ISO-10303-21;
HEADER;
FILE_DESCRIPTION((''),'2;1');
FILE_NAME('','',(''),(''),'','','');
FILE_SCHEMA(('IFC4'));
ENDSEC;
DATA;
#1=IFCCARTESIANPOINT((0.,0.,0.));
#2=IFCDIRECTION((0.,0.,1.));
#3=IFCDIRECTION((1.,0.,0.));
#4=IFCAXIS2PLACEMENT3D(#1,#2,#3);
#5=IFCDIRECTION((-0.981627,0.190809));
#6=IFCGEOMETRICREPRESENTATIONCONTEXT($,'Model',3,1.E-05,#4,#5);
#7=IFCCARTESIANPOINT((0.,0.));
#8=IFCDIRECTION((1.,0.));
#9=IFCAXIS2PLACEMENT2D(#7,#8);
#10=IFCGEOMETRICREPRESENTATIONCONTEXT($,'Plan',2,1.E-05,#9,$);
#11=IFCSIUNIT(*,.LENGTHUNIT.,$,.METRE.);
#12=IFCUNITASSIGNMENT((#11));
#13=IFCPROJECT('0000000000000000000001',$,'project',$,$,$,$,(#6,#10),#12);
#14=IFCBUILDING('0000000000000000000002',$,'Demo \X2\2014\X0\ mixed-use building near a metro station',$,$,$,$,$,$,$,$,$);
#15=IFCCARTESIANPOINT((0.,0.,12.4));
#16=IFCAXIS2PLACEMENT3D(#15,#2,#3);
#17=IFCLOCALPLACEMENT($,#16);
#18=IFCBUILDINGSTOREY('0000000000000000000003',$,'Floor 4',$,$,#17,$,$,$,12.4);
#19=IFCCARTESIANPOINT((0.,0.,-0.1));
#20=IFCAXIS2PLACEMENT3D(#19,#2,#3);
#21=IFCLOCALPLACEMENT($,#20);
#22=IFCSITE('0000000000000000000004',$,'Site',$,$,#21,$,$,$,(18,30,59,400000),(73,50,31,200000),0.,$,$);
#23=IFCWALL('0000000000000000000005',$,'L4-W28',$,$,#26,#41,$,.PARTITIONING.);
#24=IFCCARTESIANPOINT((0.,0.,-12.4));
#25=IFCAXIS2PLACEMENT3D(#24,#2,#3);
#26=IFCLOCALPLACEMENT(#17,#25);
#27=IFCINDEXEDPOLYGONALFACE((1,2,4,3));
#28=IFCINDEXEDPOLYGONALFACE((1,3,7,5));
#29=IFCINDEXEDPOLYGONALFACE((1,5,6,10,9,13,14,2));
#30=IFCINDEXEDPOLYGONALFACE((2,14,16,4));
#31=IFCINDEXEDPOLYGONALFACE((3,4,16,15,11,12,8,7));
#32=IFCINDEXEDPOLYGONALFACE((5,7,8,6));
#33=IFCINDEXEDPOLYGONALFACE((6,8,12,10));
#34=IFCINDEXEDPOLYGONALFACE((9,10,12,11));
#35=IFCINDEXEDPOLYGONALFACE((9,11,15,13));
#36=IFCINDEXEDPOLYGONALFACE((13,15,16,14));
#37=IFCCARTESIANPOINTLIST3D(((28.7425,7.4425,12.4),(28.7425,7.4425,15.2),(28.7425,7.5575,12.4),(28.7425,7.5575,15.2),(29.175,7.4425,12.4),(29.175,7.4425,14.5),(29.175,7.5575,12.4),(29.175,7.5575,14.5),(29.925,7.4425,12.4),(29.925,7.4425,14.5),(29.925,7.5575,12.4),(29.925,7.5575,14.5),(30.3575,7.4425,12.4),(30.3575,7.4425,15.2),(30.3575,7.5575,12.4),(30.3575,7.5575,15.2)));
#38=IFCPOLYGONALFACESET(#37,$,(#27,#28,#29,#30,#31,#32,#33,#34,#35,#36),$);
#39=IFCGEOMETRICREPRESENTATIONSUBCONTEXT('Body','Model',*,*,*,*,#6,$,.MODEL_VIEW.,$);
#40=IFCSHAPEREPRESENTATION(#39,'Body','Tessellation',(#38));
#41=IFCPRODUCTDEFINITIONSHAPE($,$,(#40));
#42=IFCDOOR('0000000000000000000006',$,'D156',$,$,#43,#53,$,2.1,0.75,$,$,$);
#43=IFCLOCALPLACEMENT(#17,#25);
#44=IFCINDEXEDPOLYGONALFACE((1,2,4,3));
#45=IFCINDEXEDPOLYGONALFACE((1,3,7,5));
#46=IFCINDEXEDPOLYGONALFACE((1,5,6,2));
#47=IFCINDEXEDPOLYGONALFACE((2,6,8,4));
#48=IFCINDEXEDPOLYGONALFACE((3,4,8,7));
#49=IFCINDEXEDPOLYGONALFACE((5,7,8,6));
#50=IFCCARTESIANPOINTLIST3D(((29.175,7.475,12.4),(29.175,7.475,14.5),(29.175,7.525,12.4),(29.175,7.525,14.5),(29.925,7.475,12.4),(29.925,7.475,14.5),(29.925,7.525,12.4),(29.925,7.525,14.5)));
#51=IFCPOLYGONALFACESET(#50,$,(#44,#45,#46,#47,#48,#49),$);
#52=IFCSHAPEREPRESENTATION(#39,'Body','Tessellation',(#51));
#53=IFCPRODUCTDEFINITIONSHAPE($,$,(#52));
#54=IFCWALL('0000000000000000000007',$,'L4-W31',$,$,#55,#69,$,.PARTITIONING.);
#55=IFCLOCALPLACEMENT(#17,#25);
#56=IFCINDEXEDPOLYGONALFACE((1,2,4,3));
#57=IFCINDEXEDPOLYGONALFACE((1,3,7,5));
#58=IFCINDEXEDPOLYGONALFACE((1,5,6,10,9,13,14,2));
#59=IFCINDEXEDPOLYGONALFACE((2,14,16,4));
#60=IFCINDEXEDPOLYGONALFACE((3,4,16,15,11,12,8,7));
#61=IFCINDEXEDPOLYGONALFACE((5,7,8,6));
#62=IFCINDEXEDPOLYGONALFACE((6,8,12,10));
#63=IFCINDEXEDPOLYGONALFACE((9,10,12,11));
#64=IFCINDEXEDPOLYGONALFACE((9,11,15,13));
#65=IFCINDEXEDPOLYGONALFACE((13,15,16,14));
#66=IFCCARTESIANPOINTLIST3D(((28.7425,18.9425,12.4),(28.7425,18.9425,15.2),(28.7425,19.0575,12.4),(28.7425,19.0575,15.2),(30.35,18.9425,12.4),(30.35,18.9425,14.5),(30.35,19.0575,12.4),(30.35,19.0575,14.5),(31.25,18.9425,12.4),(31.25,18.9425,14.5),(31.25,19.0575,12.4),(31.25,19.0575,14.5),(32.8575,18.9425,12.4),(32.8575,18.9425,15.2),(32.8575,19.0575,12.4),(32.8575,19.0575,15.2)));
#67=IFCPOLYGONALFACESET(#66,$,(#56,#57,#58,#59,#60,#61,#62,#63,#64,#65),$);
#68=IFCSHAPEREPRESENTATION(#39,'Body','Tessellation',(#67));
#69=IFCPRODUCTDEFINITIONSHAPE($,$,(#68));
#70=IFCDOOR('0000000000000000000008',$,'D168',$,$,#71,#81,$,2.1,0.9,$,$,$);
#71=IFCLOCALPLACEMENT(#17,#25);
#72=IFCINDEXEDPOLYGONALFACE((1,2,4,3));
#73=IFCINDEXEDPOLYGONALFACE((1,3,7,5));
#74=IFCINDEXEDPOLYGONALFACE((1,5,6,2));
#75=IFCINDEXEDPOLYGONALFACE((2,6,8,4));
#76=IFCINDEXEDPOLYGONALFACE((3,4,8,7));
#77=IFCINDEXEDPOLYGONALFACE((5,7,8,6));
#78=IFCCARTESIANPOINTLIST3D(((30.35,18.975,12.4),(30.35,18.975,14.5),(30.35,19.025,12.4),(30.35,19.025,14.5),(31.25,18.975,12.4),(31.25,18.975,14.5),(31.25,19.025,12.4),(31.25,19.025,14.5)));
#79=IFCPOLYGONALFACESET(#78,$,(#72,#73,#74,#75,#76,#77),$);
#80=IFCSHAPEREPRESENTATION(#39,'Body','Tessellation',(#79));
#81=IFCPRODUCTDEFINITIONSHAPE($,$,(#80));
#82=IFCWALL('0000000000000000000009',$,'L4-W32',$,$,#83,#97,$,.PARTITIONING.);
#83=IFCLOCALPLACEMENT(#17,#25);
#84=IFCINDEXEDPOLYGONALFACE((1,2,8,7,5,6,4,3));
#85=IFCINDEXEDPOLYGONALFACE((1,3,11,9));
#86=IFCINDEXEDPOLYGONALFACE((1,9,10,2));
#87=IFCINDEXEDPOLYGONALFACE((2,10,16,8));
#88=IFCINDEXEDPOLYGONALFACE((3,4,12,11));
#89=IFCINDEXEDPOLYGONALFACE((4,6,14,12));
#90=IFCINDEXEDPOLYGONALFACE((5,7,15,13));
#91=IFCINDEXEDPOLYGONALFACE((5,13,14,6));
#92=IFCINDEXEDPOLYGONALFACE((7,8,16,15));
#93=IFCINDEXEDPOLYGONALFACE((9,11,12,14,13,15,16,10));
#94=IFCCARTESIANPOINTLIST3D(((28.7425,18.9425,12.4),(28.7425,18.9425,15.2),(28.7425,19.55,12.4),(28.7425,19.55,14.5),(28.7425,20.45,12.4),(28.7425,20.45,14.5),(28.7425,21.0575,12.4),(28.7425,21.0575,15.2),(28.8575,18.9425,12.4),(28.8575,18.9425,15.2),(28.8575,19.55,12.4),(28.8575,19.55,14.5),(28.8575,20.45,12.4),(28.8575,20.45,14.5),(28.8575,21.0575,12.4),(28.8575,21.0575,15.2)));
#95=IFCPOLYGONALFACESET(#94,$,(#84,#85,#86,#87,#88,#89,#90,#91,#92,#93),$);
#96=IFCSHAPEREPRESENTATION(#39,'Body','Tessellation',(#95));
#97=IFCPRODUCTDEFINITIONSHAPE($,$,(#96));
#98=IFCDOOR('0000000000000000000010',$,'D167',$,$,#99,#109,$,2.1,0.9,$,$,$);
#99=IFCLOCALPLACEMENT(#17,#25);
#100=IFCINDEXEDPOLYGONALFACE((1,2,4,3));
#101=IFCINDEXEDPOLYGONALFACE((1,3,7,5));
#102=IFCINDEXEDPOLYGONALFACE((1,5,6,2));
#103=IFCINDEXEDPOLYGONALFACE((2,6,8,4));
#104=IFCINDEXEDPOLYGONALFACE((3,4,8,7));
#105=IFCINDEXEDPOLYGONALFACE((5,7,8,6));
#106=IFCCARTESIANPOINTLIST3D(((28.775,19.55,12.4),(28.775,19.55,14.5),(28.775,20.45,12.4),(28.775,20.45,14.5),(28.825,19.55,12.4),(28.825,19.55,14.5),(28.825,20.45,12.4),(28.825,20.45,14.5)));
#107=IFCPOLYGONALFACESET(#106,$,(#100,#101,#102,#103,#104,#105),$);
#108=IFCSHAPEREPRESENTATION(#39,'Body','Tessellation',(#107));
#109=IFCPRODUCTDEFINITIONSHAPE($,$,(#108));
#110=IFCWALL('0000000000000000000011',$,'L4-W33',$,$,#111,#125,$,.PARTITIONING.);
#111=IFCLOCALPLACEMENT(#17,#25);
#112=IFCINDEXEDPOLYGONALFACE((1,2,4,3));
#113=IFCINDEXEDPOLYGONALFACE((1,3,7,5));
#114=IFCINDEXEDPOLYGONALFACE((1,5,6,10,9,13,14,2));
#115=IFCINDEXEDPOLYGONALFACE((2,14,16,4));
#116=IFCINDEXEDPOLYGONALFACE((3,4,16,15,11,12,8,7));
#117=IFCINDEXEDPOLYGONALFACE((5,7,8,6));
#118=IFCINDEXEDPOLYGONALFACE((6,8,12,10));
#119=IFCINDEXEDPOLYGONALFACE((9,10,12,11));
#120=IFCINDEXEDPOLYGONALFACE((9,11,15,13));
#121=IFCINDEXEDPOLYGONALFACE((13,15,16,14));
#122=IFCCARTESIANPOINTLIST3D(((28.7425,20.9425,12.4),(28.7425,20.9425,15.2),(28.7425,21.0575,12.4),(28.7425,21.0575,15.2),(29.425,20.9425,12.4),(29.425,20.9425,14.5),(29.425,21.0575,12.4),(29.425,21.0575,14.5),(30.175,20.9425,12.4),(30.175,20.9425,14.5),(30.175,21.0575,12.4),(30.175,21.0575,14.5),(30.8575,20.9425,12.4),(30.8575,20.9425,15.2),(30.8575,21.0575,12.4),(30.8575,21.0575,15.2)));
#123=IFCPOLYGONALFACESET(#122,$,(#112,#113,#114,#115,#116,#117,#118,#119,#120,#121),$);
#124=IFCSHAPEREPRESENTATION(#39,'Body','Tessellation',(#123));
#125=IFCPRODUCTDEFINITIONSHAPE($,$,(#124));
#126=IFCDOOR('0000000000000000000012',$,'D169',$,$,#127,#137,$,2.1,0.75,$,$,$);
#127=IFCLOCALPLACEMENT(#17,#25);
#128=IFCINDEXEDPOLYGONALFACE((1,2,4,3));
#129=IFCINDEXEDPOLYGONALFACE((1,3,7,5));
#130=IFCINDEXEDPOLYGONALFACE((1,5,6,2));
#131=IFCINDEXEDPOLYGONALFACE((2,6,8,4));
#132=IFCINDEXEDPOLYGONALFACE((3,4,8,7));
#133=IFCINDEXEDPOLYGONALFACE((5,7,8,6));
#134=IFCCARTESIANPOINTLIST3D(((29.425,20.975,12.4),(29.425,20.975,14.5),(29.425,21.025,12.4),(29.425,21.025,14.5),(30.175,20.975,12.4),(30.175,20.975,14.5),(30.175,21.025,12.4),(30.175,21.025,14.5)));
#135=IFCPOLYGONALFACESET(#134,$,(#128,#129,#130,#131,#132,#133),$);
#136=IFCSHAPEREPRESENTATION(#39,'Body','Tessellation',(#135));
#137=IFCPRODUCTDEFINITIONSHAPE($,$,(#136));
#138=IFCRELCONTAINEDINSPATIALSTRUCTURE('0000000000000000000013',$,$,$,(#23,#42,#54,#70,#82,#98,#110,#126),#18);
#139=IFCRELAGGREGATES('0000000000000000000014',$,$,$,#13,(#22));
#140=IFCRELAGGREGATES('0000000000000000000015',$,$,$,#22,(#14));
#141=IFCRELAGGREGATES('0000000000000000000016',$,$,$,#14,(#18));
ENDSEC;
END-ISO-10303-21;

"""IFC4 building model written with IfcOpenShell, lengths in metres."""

from ifc_helpers import new_model, si_unit, direction, frame, origin_with_axes, origin_2d_with_axis, place, context, subcontext, project, spatial, line, indexed_curve, outline, extrude, element, fill, save


model = new_model("IFC4")

# Units and contexts
model_context = context("Model", 3, precision=1e-05, world=origin_with_axes(), true_north=direction((-0.981627, 0.190809)))
plan_context = context("Plan", 2, precision=1e-05, world=origin_2d_with_axis())
body_context = subcontext(model_context, "Body", "Model", "MODEL_VIEW")
ifc_project = project(units=[si_unit("LENGTHUNIT", "METRE")], contexts=[model_context, plan_context])

# Site, building, storey
site_placement = place(None, frame((0.0, 0.0, -0.1), z_axis=(0.0, 0.0, 1.0), x_axis=(1.0, 0.0, 0.0)))
site = spatial("IfcSite", under=ifc_project, at=site_placement, Name="Site", RefLatitude=(18, 30, 59, 400000), RefLongitude=(73, 50, 31, 200000), RefElevation=0.0)
building = spatial("IfcBuilding", under=site, Name="Demo — mixed-use building near a metro station")
storey_placement = place(None, frame((0.0, 0.0, 12.4), z_axis=(0.0, 0.0, 1.0), x_axis=(1.0, 0.0, 0.0)))
storey = spatial("IfcBuildingStorey", under=building, at=storey_placement, Name="Floor 4", Elevation=12.4)

# Wall, opening, door
wall_1_placement = place(storey_placement, frame((0.0, 0.0, -12.4), z_axis=(0.0, 0.0, 1.0), x_axis=(1.0, 0.0, 0.0)))
wall_1 = element("IfcWall", 1, at=wall_1_placement, inside=storey, Name="L4-W28", PredefinedType="PARTITIONING", context=body_context, shape_type="SweptSolid", body=[
    extrude(outline(indexed_curve([(30.3575, 7.4425), (28.7425, 7.4425), (28.7425, 7.5575), (30.3575, 7.5575)], segments=[line(1, 2, 3, 4, 1)])), frame((0.0, 0.0, 12.4), z_axis=(0.0, 0.0, 1.0), x_axis=(1.0, 0.0, 0.0)), (0.0, 0.0, 1.0), 2.8),
])
opening_1_placement = place(wall_1_placement, origin_with_axes())
opening_1 = element("IfcOpeningElement", 2, at=opening_1_placement, cuts=wall_1, context=body_context, shape_type="SweptSolid", body=[
    extrude(outline(indexed_curve([(29.925, 7.3925), (29.175, 7.3925), (29.175, 7.6075), (29.925, 7.6075)], segments=[line(1, 2, 3, 4, 1)])), frame((0.0, 0.0, 12.4), z_axis=(0.0, 0.0, 1.0), x_axis=(1.0, 0.0, 0.0)), (0.0, 0.0, 1.0), 2.1),
])
door_1_placement = place(storey_placement, frame((0.0, 0.0, -12.4), z_axis=(0.0, 0.0, 1.0), x_axis=(1.0, 0.0, 0.0)))
door_1 = element("IfcDoor", 3, at=door_1_placement, inside=storey, Name="D156", OverallHeight=2.1, OverallWidth=0.75, context=body_context, shape_type="SweptSolid", body=[
    extrude(outline(indexed_curve([(29.925, 7.475), (29.175, 7.475), (29.175, 7.525), (29.925, 7.525)], segments=[line(1, 2, 3, 4, 1)])), frame((0.0, 0.0, 12.4), z_axis=(0.0, 0.0, 1.0), x_axis=(1.0, 0.0, 0.0)), (0.0, 0.0, 1.0), 2.1),
])
fill(opening_1, door_1)

# Walls, openings, doors
wall_2_placement = place(storey_placement, frame((0.0, 0.0, -12.4), z_axis=(0.0, 0.0, 1.0), x_axis=(1.0, 0.0, 0.0)))
wall_2 = element("IfcWall", 4, at=wall_2_placement, inside=storey, Name="L4-W31", PredefinedType="PARTITIONING", context=body_context, shape_type="SweptSolid", body=[
    extrude(outline(indexed_curve([(32.8575, 18.9425), (28.7425, 18.9425), (28.7425, 19.0575), (32.8575, 19.0575)], segments=[line(1, 2, 3, 4, 1)])), frame((0.0, 0.0, 12.4), z_axis=(0.0, 0.0, 1.0), x_axis=(1.0, 0.0, 0.0)), (0.0, 0.0, 1.0), 2.8),
])
opening_2_placement = place(wall_2_placement, origin_with_axes())
opening_2 = element("IfcOpeningElement", 5, at=opening_2_placement, cuts=wall_2, context=body_context, shape_type="SweptSolid", body=[
    extrude(outline(indexed_curve([(31.25, 18.8925), (30.35, 18.8925), (30.35, 19.1075), (31.25, 19.1075)], segments=[line(1, 2, 3, 4, 1)])), frame((0.0, 0.0, 12.4), z_axis=(0.0, 0.0, 1.0), x_axis=(1.0, 0.0, 0.0)), (0.0, 0.0, 1.0), 2.1),
])
door_2_placement = place(storey_placement, frame((0.0, 0.0, -12.4), z_axis=(0.0, 0.0, 1.0), x_axis=(1.0, 0.0, 0.0)))
door_2 = element("IfcDoor", 6, at=door_2_placement, inside=storey, Name="D168", OverallHeight=2.1, OverallWidth=0.9, context=body_context, shape_type="SweptSolid", body=[
    extrude(outline(indexed_curve([(31.25, 18.975), (30.35, 18.975), (30.35, 19.025), (31.25, 19.025)], segments=[line(1, 2, 3, 4, 1)])), frame((0.0, 0.0, 12.4), z_axis=(0.0, 0.0, 1.0), x_axis=(1.0, 0.0, 0.0)), (0.0, 0.0, 1.0), 2.1),
])
fill(opening_2, door_2)
wall_3_placement = place(storey_placement, frame((0.0, 0.0, -12.4), z_axis=(0.0, 0.0, 1.0), x_axis=(1.0, 0.0, 0.0)))
wall_3 = element("IfcWall", 7, at=wall_3_placement, inside=storey, Name="L4-W32", PredefinedType="PARTITIONING", context=body_context, shape_type="SweptSolid", body=[
    extrude(outline(indexed_curve([(28.7425, 18.9425), (28.7425, 21.0575), (28.8575, 21.0575), (28.8575, 18.9425)], segments=[line(1, 2, 3, 4, 1)])), frame((0.0, 0.0, 12.4), z_axis=(0.0, 0.0, 1.0), x_axis=(1.0, 0.0, 0.0)), (0.0, 0.0, 1.0), 2.8),
])
opening_3_placement = place(wall_3_placement, origin_with_axes())
opening_3 = element("IfcOpeningElement", 8, at=opening_3_placement, cuts=wall_3, context=body_context, shape_type="SweptSolid", body=[
    extrude(outline(indexed_curve([(28.6925, 19.55), (28.6925, 20.45), (28.9075, 20.45), (28.9075, 19.55)], segments=[line(1, 2, 3, 4, 1)])), frame((0.0, 0.0, 12.4), z_axis=(0.0, 0.0, 1.0), x_axis=(1.0, 0.0, 0.0)), (0.0, 0.0, 1.0), 2.1),
])
door_3_placement = place(storey_placement, frame((0.0, 0.0, -12.4), z_axis=(0.0, 0.0, 1.0), x_axis=(1.0, 0.0, 0.0)))
door_3 = element("IfcDoor", 9, at=door_3_placement, inside=storey, Name="D167", OverallHeight=2.1, OverallWidth=0.9, context=body_context, shape_type="SweptSolid", body=[
    extrude(outline(indexed_curve([(28.775, 19.55), (28.775, 20.45), (28.825, 20.45), (28.825, 19.55)], segments=[line(1, 2, 3, 4, 1)])), frame((0.0, 0.0, 12.4), z_axis=(0.0, 0.0, 1.0), x_axis=(1.0, 0.0, 0.0)), (0.0, 0.0, 1.0), 2.1),
])
fill(opening_3, door_3)
wall_4_placement = place(storey_placement, frame((0.0, 0.0, -12.4), z_axis=(0.0, 0.0, 1.0), x_axis=(1.0, 0.0, 0.0)))
wall_4 = element("IfcWall", 10, at=wall_4_placement, inside=storey, Name="L4-W33", PredefinedType="PARTITIONING", context=body_context, shape_type="SweptSolid", body=[
    extrude(outline(indexed_curve([(30.8575, 20.9425), (28.7425, 20.9425), (28.7425, 21.0575), (30.8575, 21.0575)], segments=[line(1, 2, 3, 4, 1)])), frame((0.0, 0.0, 12.4), z_axis=(0.0, 0.0, 1.0), x_axis=(1.0, 0.0, 0.0)), (0.0, 0.0, 1.0), 2.8),
])
opening_4_placement = place(wall_4_placement, origin_with_axes())
opening_4 = element("IfcOpeningElement", 11, at=opening_4_placement, cuts=wall_4, context=body_context, shape_type="SweptSolid", body=[
    extrude(outline(indexed_curve([(30.175, 20.8925), (29.425, 20.8925), (29.425, 21.1075), (30.175, 21.1075)], segments=[line(1, 2, 3, 4, 1)])), frame((0.0, 0.0, 12.4), z_axis=(0.0, 0.0, 1.0), x_axis=(1.0, 0.0, 0.0)), (0.0, 0.0, 1.0), 2.1),
])
door_4_placement = place(storey_placement, frame((0.0, 0.0, -12.4), z_axis=(0.0, 0.0, 1.0), x_axis=(1.0, 0.0, 0.0)))
door_4 = element("IfcDoor", 12, at=door_4_placement, inside=storey, Name="D169", OverallHeight=2.1, OverallWidth=0.75, context=body_context, shape_type="SweptSolid", body=[
    extrude(outline(indexed_curve([(30.175, 20.975), (29.425, 20.975), (29.425, 21.025), (30.175, 21.025)], segments=[line(1, 2, 3, 4, 1)])), frame((0.0, 0.0, 12.4), z_axis=(0.0, 0.0, 1.0), x_axis=(1.0, 0.0, 0.0)), (0.0, 0.0, 1.0), 2.1),
])
fill(opening_4, door_4)

save(model, "model.ifc")
